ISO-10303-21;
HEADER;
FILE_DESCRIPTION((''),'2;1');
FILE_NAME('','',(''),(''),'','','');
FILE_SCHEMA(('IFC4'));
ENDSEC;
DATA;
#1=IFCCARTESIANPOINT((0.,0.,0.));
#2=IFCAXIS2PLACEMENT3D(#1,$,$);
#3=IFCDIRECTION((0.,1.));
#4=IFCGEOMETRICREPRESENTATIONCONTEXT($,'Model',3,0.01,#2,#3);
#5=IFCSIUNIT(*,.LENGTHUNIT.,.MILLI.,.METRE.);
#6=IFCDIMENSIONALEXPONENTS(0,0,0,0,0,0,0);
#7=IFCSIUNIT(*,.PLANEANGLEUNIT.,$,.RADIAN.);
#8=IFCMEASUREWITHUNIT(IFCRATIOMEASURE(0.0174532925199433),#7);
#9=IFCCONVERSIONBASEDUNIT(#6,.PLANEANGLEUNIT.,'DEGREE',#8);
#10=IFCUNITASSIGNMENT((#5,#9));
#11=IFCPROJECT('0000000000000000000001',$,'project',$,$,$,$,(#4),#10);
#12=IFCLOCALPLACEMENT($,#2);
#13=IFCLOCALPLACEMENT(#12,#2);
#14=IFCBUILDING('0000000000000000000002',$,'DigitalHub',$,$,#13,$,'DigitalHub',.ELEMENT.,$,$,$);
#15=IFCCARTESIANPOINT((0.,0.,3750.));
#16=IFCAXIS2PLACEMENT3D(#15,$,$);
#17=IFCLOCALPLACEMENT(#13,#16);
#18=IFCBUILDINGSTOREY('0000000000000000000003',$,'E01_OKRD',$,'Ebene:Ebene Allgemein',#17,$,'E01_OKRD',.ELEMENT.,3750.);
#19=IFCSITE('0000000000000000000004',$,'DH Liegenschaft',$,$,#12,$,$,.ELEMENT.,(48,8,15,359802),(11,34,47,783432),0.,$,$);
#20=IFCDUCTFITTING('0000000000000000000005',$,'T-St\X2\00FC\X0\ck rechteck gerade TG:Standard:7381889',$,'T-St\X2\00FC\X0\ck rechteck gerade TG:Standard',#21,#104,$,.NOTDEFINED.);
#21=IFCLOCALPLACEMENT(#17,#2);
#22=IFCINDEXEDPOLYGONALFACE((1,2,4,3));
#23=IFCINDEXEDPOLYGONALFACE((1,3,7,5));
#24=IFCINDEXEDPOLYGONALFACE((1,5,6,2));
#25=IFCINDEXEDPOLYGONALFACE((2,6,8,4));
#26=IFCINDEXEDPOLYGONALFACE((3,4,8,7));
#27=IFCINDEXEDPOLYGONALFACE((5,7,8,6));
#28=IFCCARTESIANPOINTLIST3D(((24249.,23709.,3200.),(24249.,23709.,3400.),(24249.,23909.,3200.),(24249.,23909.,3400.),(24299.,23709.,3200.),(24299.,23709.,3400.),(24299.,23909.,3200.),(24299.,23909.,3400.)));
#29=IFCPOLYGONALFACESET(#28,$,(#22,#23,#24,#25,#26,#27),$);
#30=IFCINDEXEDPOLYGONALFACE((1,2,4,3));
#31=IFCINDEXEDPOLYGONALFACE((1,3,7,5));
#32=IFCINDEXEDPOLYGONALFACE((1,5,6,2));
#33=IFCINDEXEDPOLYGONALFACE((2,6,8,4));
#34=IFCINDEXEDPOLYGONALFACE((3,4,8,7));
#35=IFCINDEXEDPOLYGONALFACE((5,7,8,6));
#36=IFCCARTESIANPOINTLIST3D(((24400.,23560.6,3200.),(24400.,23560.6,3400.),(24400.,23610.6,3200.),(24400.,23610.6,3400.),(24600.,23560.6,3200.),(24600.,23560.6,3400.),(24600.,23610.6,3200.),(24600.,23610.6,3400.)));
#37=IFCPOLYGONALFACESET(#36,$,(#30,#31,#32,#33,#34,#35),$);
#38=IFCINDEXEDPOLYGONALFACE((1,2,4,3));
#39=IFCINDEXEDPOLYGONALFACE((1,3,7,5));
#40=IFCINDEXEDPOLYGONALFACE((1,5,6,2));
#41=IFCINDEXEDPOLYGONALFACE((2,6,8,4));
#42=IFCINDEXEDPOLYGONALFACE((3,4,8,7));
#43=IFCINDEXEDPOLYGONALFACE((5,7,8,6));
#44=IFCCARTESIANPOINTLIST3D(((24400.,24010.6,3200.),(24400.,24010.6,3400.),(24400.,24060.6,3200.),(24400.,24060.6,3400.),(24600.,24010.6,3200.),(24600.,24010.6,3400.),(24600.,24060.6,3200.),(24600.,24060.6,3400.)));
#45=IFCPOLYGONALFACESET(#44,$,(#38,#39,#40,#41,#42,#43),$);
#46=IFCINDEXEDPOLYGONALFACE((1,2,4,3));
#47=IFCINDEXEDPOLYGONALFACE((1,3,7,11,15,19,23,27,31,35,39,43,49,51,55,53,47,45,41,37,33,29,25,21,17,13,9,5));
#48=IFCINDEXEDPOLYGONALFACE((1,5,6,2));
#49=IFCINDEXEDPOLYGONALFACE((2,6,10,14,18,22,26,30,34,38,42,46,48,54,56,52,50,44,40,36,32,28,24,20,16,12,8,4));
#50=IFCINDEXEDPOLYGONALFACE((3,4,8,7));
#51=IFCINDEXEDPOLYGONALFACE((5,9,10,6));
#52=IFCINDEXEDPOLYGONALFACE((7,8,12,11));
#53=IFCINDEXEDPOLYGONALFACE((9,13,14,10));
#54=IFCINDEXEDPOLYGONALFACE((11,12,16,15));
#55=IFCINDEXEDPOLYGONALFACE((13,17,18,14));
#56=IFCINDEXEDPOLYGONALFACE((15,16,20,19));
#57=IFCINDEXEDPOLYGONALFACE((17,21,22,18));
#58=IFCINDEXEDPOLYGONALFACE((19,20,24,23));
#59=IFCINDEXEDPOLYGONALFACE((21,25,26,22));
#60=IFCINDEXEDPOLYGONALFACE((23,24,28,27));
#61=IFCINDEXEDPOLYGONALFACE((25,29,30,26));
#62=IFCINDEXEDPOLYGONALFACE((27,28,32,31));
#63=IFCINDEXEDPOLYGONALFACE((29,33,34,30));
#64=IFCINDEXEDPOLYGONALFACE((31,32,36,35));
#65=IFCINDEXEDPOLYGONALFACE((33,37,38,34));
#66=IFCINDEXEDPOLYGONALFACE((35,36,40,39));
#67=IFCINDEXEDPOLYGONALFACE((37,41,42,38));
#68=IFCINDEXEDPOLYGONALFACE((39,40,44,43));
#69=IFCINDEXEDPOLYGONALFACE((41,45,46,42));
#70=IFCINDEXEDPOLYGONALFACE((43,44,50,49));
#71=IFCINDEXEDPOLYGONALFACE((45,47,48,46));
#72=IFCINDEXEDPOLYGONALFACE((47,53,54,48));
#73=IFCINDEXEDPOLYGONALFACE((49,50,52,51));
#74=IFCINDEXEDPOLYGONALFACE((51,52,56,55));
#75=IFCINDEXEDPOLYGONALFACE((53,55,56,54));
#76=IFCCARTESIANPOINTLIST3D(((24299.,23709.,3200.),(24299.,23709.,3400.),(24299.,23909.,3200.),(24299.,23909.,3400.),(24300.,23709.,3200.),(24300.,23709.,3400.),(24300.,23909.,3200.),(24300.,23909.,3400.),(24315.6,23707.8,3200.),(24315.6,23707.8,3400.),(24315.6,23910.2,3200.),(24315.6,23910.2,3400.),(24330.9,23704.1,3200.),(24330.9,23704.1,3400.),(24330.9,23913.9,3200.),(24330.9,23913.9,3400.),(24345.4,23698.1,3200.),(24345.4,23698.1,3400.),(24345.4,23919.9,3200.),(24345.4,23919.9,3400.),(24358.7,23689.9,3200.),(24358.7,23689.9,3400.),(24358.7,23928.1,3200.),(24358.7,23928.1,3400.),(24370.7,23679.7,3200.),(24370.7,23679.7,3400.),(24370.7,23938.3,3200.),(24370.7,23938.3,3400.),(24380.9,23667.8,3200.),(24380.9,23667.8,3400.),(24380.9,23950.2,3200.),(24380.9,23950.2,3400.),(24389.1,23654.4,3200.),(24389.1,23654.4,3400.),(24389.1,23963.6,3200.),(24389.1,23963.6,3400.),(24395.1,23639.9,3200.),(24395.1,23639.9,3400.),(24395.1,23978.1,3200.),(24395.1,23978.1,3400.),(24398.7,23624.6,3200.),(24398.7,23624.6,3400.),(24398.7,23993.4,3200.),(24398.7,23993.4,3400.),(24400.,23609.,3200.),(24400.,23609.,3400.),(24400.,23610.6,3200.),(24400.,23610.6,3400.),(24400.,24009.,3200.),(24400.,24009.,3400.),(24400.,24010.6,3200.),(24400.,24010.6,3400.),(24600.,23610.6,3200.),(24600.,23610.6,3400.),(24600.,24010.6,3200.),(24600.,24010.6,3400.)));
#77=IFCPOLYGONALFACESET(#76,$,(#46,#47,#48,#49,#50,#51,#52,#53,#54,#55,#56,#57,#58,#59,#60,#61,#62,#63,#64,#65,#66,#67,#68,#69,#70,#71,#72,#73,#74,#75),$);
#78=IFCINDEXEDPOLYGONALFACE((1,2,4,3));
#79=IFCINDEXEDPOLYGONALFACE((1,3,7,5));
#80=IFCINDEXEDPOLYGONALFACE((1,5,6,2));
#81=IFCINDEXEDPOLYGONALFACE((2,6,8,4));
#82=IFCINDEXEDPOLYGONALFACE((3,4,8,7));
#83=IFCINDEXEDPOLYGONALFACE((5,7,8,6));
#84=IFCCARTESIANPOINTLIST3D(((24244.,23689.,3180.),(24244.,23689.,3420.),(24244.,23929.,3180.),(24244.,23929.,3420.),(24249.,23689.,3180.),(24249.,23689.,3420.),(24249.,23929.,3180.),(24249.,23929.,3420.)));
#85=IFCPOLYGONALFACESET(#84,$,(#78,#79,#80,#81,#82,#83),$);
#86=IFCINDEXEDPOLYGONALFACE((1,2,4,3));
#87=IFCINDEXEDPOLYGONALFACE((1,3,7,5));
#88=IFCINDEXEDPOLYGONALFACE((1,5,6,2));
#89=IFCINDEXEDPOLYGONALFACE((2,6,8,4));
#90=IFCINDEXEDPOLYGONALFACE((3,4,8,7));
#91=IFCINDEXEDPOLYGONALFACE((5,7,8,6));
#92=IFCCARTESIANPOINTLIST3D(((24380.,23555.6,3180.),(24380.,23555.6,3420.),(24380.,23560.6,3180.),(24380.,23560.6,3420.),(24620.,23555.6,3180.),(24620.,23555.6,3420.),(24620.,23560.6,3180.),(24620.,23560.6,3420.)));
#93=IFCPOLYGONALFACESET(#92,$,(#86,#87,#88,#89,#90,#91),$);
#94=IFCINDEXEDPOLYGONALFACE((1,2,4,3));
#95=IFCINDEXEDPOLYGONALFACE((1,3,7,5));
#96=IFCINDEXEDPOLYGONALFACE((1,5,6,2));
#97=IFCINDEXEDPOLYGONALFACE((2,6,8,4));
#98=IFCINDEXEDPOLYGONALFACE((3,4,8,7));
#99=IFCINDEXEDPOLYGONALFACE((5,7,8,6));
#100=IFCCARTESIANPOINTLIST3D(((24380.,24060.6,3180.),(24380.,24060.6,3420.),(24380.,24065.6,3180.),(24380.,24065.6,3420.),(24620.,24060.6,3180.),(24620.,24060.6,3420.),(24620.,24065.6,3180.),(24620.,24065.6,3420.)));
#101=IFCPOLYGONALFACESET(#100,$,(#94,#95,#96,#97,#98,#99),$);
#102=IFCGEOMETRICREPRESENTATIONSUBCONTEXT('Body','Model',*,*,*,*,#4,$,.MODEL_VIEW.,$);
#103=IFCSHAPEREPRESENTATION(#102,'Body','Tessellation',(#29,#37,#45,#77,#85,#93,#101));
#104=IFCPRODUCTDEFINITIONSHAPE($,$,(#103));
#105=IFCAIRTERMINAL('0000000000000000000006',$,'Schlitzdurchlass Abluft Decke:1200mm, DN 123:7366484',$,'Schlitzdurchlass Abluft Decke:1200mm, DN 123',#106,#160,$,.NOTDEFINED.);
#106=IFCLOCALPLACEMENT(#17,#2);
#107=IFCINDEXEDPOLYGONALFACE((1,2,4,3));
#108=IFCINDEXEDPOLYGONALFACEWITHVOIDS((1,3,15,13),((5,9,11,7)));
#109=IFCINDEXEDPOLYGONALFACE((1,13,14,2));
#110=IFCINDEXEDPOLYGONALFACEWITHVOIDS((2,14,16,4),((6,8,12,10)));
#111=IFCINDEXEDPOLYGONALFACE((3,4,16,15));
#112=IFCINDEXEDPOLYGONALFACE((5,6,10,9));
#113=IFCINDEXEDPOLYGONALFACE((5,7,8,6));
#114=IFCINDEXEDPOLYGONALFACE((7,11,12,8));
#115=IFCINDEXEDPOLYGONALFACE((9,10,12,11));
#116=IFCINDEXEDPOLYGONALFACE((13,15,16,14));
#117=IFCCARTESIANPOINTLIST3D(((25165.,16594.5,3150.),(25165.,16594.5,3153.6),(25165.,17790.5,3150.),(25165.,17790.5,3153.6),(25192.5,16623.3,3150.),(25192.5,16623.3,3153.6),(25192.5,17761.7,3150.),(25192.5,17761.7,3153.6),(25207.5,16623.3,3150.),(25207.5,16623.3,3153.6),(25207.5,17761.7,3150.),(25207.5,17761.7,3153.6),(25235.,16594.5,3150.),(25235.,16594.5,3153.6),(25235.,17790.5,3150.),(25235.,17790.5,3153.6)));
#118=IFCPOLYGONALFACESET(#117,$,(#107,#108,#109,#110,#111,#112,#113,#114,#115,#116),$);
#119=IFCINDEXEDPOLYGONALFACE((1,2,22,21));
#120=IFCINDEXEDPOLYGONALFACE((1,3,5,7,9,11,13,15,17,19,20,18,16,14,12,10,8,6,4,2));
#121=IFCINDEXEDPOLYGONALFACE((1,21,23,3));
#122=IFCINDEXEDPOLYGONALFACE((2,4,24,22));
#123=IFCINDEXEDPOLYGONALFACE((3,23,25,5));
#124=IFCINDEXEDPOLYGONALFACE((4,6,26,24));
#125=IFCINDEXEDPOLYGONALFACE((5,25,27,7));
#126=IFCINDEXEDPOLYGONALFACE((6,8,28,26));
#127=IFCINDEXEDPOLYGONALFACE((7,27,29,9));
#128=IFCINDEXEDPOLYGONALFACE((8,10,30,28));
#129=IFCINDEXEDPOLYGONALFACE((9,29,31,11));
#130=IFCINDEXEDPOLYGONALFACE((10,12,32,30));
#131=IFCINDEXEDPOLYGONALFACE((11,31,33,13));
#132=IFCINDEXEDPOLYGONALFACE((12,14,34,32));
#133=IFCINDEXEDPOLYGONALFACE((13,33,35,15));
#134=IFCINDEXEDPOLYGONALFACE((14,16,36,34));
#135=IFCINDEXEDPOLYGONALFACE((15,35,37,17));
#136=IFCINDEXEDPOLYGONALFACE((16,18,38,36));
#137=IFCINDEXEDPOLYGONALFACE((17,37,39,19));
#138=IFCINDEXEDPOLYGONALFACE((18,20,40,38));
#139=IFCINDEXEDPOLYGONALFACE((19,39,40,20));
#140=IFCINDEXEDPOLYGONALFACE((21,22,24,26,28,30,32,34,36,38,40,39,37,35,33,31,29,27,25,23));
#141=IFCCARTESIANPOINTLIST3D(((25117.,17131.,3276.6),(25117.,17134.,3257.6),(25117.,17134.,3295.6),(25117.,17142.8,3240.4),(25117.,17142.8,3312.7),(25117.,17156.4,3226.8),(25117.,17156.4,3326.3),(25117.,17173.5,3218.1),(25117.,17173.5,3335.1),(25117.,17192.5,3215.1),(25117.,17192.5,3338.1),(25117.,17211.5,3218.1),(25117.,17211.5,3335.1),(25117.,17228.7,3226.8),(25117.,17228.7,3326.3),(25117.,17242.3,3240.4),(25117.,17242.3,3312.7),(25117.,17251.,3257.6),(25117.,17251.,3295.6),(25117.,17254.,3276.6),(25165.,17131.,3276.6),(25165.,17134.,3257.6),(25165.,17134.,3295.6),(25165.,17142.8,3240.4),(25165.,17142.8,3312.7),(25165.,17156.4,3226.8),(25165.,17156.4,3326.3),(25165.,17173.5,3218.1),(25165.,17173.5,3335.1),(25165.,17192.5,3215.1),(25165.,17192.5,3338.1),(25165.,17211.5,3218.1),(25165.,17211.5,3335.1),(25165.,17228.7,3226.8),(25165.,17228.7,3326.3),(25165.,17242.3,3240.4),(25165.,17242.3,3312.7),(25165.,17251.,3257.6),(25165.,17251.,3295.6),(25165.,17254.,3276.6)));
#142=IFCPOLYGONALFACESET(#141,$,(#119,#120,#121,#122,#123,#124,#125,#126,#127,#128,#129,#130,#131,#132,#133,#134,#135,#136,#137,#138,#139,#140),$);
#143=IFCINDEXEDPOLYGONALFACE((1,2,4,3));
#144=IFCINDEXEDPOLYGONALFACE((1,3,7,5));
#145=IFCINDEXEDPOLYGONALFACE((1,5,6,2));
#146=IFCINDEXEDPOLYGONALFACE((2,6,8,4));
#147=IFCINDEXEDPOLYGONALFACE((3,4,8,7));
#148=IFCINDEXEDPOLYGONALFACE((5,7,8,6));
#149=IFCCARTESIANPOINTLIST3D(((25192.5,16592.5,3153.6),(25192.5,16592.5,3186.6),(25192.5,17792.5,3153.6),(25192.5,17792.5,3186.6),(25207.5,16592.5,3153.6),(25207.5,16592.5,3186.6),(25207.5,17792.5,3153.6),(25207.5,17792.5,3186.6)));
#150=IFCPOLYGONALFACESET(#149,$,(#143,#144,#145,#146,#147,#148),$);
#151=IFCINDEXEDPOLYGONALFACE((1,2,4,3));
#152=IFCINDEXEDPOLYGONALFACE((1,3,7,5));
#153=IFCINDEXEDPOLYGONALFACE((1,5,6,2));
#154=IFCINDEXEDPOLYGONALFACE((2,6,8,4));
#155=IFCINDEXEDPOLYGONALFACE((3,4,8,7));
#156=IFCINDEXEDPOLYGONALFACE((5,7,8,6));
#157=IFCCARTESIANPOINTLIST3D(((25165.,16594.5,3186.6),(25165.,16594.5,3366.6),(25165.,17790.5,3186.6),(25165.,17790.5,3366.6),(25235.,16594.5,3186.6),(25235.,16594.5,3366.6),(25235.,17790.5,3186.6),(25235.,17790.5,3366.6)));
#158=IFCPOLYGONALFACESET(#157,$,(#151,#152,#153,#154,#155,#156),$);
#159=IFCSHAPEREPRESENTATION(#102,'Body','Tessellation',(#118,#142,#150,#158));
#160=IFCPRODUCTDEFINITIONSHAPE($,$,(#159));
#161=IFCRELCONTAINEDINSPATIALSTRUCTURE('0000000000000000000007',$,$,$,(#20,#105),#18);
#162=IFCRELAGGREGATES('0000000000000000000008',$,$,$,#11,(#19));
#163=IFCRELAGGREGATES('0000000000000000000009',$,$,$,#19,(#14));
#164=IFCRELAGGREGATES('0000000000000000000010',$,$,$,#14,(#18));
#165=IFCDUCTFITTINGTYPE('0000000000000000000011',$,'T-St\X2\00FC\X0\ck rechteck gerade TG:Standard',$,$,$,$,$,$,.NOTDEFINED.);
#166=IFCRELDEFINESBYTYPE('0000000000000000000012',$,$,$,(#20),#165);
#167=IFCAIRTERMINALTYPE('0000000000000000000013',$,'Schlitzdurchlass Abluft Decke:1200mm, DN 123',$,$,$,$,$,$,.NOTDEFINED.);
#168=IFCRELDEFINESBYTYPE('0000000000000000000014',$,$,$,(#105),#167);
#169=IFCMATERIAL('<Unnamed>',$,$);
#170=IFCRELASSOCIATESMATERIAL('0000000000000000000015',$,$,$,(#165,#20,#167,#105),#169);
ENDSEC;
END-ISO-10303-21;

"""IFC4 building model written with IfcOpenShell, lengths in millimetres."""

from ifc_helpers import new_model, entity, si_unit, converted_unit, direction, frame, origin, place, context, subcontext, project, spatial, indexed_curve, outline, extrude, source, transform, mapped, material, type_object, type_shapes, element, save


model = new_model("IFC4")

# Units and contexts
model_context = context("Model", 3, precision=0.01, world=origin(), true_north=direction((0.0, 1.0)))
body_context = subcontext(model_context, "Body", "Model", "MODEL_VIEW")
ifc_project = project(units=[si_unit("LENGTHUNIT", "METRE", prefix="MILLI"), converted_unit("PLANEANGLEUNIT", "DEGREE", entity("IfcRatioMeasure", 0.0174532925199433), si_unit("PLANEANGLEUNIT", "RADIAN"), dimensions=[0, 0, 0, 0, 0, 0, 0])], contexts=[model_context])

# Site, building, storey
site_placement = place(None, origin())
site = spatial("IfcSite", under=ifc_project, at=site_placement, Name="DH Liegenschaft", CompositionType="ELEMENT", RefLatitude=(48, 8, 15, 359802), RefLongitude=(11, 34, 47, 783432), RefElevation=0.0)
building_placement = place(site_placement, origin())
building = spatial("IfcBuilding", under=site, at=building_placement, Name="DigitalHub", LongName="DigitalHub", CompositionType="ELEMENT")
storey_placement = place(building_placement, frame((0.0, 0.0, 3750.0)))
storey = spatial("IfcBuildingStorey", under=building, at=storey_placement, Name="E01_OKRD", ObjectType="Ebene:Ebene Allgemein", LongName="E01_OKRD", CompositionType="ELEMENT", Elevation=3750.0)

# Shared definitions
ifc_material_1 = material(Name="<Unnamed>")

# Duct fitting
duct_fitting_type_1 = type_object("IfcDuctFittingType", Name="T-Stück rechteck gerade TG:Standard", PredefinedType="NOTDEFINED", material=ifc_material_1)
shared_shape_1 = source(origin(), body_context, "Body", "SweptSolid", [
    extrude(outline(indexed_curve([(-25.0, -100.0), (25.0, -100.0), (25.0, 100.0), (-25.0, 100.0), (-25.0, -100.0)], self_intersect=False)), frame((0.0, -226.0, -100.0), z_axis=(0.0, 0.0, 1.0), x_axis=(0.0, -1.0, 0.0)), (0.0, 0.0, 1.0), 200.0),
    extrude(outline(indexed_curve([(-25.0, -100.0), (25.0, -100.0), (25.0, 100.0), (-25.0, 100.0), (-25.0, -100.0)], self_intersect=False)), frame((223.4, 0.0, -100.0), z_axis=(0.0, 0.0, 1.0), x_axis=(-1.0, 0.0, 0.0)), (0.0, 0.0, 1.0), 200.0),
    extrude(outline(indexed_curve([(-25.0, -100.0), (25.0, -100.0), (25.0, 100.0), (-25.0, 100.0), (-25.0, -100.0)], self_intersect=False)), frame((-226.6, 0.0, -100.0)), (0.0, 0.0, 1.0), 200.0),
    extrude(outline(indexed_curve([(-200.6, 0.2), (-185.0, -1.0), (-169.7, -4.7), (-155.2, -10.7), (-141.9, -18.9), (-129.9, -29.1), (-119.7, -41.0), (-111.5, -54.4), (-105.5, -68.9), (-101.9, -84.2), (-100.6, -99.8), (-100.6, -100.8), (99.4, -100.8), (99.4, -99.8), (100.6, -84.2), (104.3, -68.9), (110.3, -54.4), (118.5, -41.0), (128.6, -29.1), (140.6, -18.9), (154.0, -10.7), (168.5, -4.7), (183.7, -1.0), (199.4, 0.2), (201.0, 0.2), (201.0, 200.2), (-199.0, 200.2), (-199.0, 0.2), (-200.6, 0.2)], self_intersect=False)), frame((-0.6, -100.2, -100.0), z_axis=(0.0, 0.0, -1.0), x_axis=(-1.0, 0.0, 0.0)), (0.0, 0.0, -1.0), 200.0),
    extrude(outline(indexed_curve([(-2.5, -120.0), (2.5, -120.0), (2.5, 120.0), (-2.5, 120.0), (-2.5, -120.0)], self_intersect=False)), frame((0.0, -253.5, -120.0), z_axis=(0.0, 0.0, 1.0), x_axis=(0.0, 1.0, 0.0)), (0.0, 0.0, 1.0), 240.0),
    extrude(outline(indexed_curve([(-2.5, -120.0), (2.5, -120.0), (2.5, 120.0), (-2.5, 120.0), (-2.5, -120.0)], self_intersect=False)), frame((250.9, 0.0, -120.0), z_axis=(0.0, 0.0, 1.0), x_axis=(-1.0, 0.0, 0.0)), (0.0, 0.0, 1.0), 240.0),
    extrude(outline(indexed_curve([(-2.5, -120.0), (2.5, -120.0), (2.5, 120.0), (-2.5, 120.0), (-2.5, -120.0)], self_intersect=False)), frame((-254.1, 0.0, -120.0), z_axis=(0.0, 0.0, 1.0), x_axis=(-1.0, 0.0, 0.0)), (0.0, 0.0, 1.0), 240.0),
])
type_shapes(duct_fitting_type_1, [shared_shape_1])
duct_fitting_placement = place(storey_placement, frame((24500.0, 23809.0, 3300.0), z_axis=(0.0, 0.0, 1.0), x_axis=(0.0, -1.0, 0.0)))
element("IfcDuctFitting", 1, at=duct_fitting_placement, inside=storey, type_object=duct_fitting_type_1, material=ifc_material_1, Name="T-Stück rechteck gerade TG:Standard:7381889", ObjectType="T-Stück rechteck gerade TG:Standard", PredefinedType="NOTDEFINED", context=body_context, shape_type="MappedRepresentation", body=[
    mapped(shared_shape_1, transform((0.0, 0.0, 0.0), scale=1.0)),
])

# Air terminal
air_terminal_type_1 = type_object("IfcAirTerminalType", Name="Schlitzdurchlass Abluft Decke:1200mm, DN 123", PredefinedType="NOTDEFINED", material=ifc_material_1)
shared_shape_2 = source(origin(), body_context, "Body", "SweptSolid", [
    extrude(outline(indexed_curve([(-598.0, -35.0), (598.0, -35.0), (598.0, 35.0), (-598.0, 35.0), (-598.0, -35.0)], self_intersect=False), holes=[indexed_curve([(-569.2, -7.5), (-569.2, 7.5), (569.2, 7.5), (569.2, -7.5), (-569.2, -7.5)], self_intersect=False)]), frame((0.0, 0.0, 0.0), z_axis=(0.0, 0.0, 1.0), x_axis=(-1.0, 0.0, 0.0)), (0.0, 0.0, 1.0), 3.6),
    extrude(outline(indexed_curve([(61.5, 0.0), (58.5, 19.0), (49.8, 36.1), (36.1, 49.8), (19.0, 58.5), (0.0, 61.5), (-19.0, 58.5), (-36.1, 49.8), (-49.8, 36.1), (-58.5, 19.0), (-61.5, 0.0), (-58.5, -19.0), (-49.8, -36.1), (-36.1, -49.8), (-19.0, -58.5), (0.0, -61.5), (19.0, -58.5), (36.1, -49.8), (49.8, -36.1), (58.5, -19.0), (61.5, 0.0)], self_intersect=False)), frame((0.0, 35.0, 126.6), z_axis=(0.0, 1.0, 0.0), x_axis=(-1.0, 0.0, 0.0)), (0.0, 0.0, 1.0), 48.0),
    extrude(outline(indexed_curve([(-600.0, -7.5), (600.0, -7.5), (600.0, 7.5), (-600.0, 7.5), (-600.0, -7.5)], self_intersect=False)), frame((0.0, 0.0, 3.6), z_axis=(0.0, 0.0, 1.0), x_axis=(-1.0, 0.0, 0.0)), (0.0, 0.0, 1.0), 33.0),
    extrude(outline(indexed_curve([(-598.0, -35.0), (598.0, -35.0), (598.0, 35.0), (-598.0, 35.0), (-598.0, -35.0)], self_intersect=False)), frame((0.0, 0.0, 36.6), z_axis=(0.0, 0.0, 1.0), x_axis=(-1.0, 0.0, 0.0)), (0.0, 0.0, 1.0), 180.0),
])
type_shapes(air_terminal_type_1, [shared_shape_2])
for number, where, z_axis, x_axis, name in (
    (2, (25200.0, 17192.5, 3150.0), (0.0, 0.0, 1.0), (0.0, 1.0, 0.0), "Schlitzdurchlass Abluft Decke:1200mm, DN 123:7366484"),
):
    element("IfcAirTerminal", number, at=place(storey_placement, frame(where, z_axis=z_axis, x_axis=x_axis)), inside=storey, type_object=air_terminal_type_1, material=ifc_material_1, Name=name, ObjectType="Schlitzdurchlass Abluft Decke:1200mm, DN 123", PredefinedType="NOTDEFINED", context=body_context, shape_type="MappedRepresentation", body=[
        mapped(shared_shape_2, transform((0.0, 0.0, 0.0), scale=1.0)),
    ])

save(model, "model.ifc")
